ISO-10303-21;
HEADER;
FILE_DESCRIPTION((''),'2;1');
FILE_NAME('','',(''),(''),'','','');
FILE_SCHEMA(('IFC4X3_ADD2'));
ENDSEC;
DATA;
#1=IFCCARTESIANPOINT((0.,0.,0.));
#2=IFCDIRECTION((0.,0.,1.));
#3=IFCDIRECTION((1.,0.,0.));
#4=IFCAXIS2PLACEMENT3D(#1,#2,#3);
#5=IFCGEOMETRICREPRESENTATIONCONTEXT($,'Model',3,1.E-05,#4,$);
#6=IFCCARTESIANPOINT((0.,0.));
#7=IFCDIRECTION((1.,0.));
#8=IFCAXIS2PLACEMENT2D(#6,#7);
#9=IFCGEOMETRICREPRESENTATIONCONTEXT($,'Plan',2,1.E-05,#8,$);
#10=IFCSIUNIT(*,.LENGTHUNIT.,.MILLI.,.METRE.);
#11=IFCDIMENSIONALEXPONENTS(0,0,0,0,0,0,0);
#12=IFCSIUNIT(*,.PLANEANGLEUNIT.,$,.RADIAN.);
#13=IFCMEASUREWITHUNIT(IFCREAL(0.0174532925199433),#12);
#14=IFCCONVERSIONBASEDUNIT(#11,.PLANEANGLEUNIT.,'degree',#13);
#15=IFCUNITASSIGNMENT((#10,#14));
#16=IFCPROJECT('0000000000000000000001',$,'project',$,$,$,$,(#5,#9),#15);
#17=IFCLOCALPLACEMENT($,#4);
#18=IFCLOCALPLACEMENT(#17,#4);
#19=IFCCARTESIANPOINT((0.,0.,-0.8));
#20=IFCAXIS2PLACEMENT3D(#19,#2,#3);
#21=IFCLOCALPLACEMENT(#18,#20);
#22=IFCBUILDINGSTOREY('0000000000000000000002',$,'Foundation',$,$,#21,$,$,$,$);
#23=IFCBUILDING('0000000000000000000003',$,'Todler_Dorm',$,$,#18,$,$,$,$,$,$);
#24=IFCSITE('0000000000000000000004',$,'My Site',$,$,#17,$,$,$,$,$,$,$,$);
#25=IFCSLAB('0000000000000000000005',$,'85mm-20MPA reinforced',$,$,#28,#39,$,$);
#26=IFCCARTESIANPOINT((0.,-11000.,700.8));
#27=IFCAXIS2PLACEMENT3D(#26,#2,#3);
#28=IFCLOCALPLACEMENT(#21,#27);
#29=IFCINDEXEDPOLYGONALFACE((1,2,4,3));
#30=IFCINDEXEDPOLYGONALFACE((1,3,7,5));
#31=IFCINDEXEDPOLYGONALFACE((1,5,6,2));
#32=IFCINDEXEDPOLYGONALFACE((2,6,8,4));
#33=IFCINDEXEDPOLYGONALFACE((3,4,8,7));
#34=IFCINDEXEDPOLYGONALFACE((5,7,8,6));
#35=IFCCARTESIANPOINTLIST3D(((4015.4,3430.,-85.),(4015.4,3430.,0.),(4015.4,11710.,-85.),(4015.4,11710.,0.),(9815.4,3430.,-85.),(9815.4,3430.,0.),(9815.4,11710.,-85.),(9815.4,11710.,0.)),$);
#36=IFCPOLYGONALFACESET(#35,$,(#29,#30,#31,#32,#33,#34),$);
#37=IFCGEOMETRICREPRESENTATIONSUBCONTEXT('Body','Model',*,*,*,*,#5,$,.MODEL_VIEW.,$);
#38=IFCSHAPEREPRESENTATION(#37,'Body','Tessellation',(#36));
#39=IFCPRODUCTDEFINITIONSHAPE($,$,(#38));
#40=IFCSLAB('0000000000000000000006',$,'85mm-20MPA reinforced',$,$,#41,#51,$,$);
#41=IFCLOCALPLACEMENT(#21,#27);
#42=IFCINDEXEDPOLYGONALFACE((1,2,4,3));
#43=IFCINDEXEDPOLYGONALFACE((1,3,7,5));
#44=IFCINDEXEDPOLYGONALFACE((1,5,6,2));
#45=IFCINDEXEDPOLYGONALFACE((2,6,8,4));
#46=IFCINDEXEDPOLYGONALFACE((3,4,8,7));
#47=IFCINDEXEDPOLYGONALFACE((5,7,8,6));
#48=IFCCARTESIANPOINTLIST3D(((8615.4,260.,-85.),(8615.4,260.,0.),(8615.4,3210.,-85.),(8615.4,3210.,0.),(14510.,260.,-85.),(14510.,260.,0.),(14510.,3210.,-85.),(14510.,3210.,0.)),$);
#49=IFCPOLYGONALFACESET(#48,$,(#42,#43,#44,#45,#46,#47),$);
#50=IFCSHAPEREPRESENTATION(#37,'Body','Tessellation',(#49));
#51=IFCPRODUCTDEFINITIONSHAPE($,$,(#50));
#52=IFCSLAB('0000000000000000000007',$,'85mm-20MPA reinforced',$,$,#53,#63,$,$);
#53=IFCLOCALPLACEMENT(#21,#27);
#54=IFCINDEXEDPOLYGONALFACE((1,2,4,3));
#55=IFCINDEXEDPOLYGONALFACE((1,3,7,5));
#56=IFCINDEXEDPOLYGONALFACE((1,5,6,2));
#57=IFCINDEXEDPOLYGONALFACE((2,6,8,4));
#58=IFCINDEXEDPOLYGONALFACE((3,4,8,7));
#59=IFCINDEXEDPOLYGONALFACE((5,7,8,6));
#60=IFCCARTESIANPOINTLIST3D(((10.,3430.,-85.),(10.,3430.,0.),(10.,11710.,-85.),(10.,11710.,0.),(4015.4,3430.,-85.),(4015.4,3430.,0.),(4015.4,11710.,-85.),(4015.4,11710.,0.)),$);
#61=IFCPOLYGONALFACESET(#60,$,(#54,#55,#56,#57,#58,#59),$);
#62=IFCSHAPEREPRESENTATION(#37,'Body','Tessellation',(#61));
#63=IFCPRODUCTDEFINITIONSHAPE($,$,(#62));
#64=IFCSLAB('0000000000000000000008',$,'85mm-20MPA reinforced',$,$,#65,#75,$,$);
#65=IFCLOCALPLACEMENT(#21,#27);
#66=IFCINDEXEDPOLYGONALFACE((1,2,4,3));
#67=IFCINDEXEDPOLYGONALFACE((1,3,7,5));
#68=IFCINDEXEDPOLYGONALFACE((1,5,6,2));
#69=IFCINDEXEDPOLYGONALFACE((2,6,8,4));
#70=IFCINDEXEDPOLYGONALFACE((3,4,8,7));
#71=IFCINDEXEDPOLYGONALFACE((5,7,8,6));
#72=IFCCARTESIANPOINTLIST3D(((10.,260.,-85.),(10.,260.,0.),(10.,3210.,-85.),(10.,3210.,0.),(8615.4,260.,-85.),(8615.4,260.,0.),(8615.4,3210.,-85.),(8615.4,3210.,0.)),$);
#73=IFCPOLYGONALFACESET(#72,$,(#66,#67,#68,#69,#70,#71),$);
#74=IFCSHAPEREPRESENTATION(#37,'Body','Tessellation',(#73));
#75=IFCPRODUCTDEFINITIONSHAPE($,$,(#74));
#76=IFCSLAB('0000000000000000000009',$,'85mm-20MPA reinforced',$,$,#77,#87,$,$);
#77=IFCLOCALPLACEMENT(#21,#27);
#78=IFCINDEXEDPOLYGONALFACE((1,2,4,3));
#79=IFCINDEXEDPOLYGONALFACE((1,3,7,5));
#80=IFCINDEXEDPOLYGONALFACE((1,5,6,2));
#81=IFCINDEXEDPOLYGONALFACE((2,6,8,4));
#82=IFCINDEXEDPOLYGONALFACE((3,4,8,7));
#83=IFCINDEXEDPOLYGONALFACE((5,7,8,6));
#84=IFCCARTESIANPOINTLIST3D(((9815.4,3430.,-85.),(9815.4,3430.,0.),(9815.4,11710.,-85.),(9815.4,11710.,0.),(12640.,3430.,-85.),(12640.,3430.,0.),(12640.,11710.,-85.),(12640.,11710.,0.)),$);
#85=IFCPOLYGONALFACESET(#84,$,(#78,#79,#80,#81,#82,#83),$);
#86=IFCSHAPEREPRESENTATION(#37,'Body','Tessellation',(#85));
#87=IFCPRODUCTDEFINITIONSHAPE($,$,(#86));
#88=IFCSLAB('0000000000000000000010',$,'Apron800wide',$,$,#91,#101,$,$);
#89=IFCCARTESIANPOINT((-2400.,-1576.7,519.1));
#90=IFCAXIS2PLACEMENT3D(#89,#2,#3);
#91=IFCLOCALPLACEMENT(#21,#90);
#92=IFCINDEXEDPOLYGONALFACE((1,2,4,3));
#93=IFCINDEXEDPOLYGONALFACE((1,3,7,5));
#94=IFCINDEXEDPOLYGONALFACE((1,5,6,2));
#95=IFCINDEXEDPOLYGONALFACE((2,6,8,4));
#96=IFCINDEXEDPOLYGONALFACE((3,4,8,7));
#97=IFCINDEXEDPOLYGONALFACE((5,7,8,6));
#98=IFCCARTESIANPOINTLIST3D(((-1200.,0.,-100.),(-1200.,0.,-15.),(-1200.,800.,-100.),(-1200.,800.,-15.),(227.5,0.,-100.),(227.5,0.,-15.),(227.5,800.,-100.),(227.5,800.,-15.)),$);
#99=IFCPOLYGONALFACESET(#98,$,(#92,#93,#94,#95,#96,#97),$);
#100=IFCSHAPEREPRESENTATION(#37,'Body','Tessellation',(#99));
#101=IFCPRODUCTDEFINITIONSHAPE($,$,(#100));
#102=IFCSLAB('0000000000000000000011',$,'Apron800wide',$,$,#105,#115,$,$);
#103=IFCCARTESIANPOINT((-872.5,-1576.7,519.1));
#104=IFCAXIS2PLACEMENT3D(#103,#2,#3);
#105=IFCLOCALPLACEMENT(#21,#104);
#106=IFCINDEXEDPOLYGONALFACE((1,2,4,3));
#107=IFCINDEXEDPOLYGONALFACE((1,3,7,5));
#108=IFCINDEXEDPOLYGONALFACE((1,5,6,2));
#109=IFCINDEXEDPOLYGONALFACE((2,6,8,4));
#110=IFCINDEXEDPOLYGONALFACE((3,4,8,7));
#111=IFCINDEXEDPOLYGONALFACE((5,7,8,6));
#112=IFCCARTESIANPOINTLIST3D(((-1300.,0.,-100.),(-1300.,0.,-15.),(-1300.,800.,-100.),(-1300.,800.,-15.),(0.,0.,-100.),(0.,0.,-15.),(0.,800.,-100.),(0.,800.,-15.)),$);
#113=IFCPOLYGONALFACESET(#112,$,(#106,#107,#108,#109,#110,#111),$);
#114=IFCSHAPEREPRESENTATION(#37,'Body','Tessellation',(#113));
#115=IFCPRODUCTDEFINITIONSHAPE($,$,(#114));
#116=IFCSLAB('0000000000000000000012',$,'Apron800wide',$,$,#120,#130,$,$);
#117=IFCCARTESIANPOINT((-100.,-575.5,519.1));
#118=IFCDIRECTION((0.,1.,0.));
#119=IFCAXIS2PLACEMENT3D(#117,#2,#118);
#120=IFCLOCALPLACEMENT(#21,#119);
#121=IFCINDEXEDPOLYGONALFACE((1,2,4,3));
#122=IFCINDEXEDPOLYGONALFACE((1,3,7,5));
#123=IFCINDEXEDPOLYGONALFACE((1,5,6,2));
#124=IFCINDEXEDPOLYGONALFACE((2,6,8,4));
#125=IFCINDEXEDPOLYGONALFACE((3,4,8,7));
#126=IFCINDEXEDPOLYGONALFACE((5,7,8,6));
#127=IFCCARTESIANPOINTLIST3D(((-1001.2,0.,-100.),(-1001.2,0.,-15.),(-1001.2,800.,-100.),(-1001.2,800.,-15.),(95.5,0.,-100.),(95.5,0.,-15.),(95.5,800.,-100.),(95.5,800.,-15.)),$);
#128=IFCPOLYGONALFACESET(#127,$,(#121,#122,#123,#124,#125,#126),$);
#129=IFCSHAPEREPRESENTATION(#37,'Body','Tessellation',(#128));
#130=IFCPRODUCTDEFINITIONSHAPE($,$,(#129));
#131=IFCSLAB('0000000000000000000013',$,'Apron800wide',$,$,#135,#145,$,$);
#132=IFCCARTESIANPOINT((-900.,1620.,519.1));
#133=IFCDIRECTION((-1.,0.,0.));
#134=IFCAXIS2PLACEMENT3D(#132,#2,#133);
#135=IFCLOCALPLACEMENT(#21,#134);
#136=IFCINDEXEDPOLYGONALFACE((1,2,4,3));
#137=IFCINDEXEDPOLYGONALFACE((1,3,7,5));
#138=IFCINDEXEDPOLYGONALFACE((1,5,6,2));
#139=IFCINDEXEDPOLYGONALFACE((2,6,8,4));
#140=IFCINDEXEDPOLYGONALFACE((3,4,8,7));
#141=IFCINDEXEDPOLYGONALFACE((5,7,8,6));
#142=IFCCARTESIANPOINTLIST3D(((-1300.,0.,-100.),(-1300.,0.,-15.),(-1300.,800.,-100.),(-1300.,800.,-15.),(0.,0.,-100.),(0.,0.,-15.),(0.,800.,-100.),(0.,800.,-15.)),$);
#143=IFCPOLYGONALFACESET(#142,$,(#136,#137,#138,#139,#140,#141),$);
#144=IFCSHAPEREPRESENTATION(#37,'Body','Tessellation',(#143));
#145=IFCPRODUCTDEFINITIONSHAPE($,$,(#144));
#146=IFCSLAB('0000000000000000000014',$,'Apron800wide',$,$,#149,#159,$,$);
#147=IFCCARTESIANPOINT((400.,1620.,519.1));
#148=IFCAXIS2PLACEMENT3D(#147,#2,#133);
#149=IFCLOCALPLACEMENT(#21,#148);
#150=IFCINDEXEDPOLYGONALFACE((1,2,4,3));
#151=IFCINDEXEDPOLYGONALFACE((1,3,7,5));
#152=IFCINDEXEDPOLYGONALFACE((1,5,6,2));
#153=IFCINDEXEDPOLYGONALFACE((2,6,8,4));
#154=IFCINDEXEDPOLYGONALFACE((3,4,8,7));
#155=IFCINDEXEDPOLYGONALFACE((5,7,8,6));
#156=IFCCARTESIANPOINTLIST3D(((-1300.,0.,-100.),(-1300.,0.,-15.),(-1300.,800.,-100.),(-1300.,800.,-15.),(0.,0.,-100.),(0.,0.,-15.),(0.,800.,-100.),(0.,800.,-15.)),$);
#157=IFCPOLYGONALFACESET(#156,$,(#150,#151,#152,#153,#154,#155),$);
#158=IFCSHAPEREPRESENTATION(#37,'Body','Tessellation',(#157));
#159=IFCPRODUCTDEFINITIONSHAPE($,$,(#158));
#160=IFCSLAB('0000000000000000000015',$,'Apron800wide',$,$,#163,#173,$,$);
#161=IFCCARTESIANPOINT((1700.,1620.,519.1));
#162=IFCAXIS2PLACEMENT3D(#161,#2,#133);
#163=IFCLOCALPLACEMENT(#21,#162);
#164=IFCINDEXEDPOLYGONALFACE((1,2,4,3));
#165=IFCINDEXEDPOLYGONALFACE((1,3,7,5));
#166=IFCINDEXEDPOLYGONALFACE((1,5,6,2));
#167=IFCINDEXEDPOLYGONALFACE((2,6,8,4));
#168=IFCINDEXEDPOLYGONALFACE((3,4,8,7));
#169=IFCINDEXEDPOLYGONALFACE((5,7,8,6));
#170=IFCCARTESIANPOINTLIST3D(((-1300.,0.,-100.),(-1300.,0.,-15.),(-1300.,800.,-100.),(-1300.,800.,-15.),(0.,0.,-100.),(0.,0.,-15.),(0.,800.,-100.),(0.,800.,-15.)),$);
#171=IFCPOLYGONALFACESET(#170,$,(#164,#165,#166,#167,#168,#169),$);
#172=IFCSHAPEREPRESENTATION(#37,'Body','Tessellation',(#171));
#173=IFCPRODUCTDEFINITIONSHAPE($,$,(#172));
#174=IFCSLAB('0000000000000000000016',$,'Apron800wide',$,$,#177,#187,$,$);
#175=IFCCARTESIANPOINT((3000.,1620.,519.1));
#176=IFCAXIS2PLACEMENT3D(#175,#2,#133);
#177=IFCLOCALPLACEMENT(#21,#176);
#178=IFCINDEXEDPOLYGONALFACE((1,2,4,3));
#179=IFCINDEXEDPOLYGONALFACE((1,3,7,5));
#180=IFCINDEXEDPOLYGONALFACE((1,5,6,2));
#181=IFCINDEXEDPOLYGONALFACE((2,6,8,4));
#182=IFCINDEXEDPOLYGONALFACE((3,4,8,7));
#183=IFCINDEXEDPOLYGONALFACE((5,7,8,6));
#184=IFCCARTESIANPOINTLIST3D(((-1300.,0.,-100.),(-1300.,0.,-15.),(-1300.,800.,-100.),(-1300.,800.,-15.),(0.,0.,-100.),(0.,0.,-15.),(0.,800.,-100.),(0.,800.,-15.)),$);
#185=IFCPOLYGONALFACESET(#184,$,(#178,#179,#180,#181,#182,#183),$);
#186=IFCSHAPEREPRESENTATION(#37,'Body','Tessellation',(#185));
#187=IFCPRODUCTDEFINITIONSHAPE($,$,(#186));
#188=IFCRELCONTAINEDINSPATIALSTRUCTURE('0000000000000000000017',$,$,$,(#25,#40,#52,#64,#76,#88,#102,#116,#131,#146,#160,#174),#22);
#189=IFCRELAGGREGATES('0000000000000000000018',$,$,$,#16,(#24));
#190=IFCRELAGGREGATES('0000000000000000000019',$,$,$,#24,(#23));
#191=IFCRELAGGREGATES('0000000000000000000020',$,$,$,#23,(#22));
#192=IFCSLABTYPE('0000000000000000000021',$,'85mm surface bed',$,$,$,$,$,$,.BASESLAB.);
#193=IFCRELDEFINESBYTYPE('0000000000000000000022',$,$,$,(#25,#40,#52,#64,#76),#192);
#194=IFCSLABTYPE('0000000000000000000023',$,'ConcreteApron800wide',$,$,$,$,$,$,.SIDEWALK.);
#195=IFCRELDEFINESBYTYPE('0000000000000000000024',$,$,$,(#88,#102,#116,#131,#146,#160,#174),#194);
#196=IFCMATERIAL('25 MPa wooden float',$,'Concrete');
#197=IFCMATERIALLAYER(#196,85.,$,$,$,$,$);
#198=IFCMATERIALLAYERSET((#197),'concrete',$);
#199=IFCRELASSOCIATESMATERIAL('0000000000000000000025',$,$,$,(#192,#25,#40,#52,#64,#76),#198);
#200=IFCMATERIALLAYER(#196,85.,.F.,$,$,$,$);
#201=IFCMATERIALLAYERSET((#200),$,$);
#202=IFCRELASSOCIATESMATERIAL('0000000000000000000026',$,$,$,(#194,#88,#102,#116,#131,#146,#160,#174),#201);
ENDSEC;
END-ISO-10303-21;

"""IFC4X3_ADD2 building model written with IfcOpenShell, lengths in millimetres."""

from ifc_helpers import new_model, entity, si_unit, converted_unit, frame, origin_with_axes, origin_2d_with_axis, place, context, subcontext, project, spatial, indexed_curve, outline, extrude, material, layer, layer_set, layer_usage, type_object, element, save


model = new_model("IFC4X3_ADD2")

# Units and contexts
model_context = context("Model", 3, precision=1e-05, world=origin_with_axes())
plan_context = context("Plan", 2, precision=1e-05, world=origin_2d_with_axis())
body_context = subcontext(model_context, "Body", "Model", "MODEL_VIEW")
ifc_project = project(units=[si_unit("LENGTHUNIT", "METRE", prefix="MILLI"), converted_unit("PLANEANGLEUNIT", "degree", entity("IfcReal", 0.0174532925199433), si_unit("PLANEANGLEUNIT", "RADIAN"), dimensions=[0, 0, 0, 0, 0, 0, 0])], contexts=[model_context, plan_context])

# Site, building, storey
site_placement = place(None, origin_with_axes())
site = spatial("IfcSite", under=ifc_project, at=site_placement, Name="My Site")
building_placement = place(site_placement, origin_with_axes())
building = spatial("IfcBuilding", under=site, at=building_placement, Name="Todler_Dorm")
storey_placement = place(building_placement, frame((0.0, 0.0, -0.8), z_axis=(0.0, 0.0, 1.0), x_axis=(1.0, 0.0, 0.0)))
storey = spatial("IfcBuildingStorey", under=building, at=storey_placement, Name="Foundation")

# Slabs
ifc_material_1 = material(Name="25 MPa wooden float", Category="Concrete")
ifc_layer_1 = layer(ifc_material_1, 85.0)
ifc_layer_set_1 = layer_set([ifc_layer_1], Name="concrete")
ifc_layer_usage_1 = layer_usage(ifc_layer_set_1, "AXIS3", "POSITIVE", -85.0)
slab_type_1 = type_object("IfcSlabType", Name="85mm surface bed", PredefinedType="BASESLAB", material=ifc_layer_set_1)
slab_1_placement = place(storey_placement, frame((0.0, -11000.0, 700.8), z_axis=(0.0, 0.0, 1.0), x_axis=(1.0, 0.0, 0.0)))
element("IfcSlab", 1, at=slab_1_placement, inside=storey, type_object=slab_type_1, material=ifc_layer_usage_1, Name="85mm-20MPA reinforced", context=body_context, shape_type="SweptSolid", body=[
    extrude(outline(indexed_curve([(4015.4, 11710.0), (9815.4, 11710.0), (9815.4, 3430.0), (4015.4, 3430.0), (4015.4, 11710.0)])), frame((0.0, 0.0, -85.0), z_axis=(0.0, 0.0, 1.0), x_axis=(1.0, 0.0, 0.0)), (0.0, 0.0, 1.0), 85.0),
])
ifc_layer_usage_2 = layer_usage(ifc_layer_set_1, "AXIS3", "POSITIVE", -85.0)
slab_2_placement = place(storey_placement, frame((0.0, -11000.0, 700.8), z_axis=(0.0, 0.0, 1.0), x_axis=(1.0, 0.0, 0.0)))
element("IfcSlab", 2, at=slab_2_placement, inside=storey, type_object=slab_type_1, material=ifc_layer_usage_2, Name="85mm-20MPA reinforced", context=body_context, shape_type="SweptSolid", body=[
    extrude(outline(indexed_curve([(8615.4, 3210.0), (14510.0, 3210.0), (14510.0, 260.0), (8615.4, 260.0), (8615.4, 3210.0)])), frame((0.0, 0.0, -85.0), z_axis=(0.0, 0.0, 1.0), x_axis=(1.0, 0.0, 0.0)), (0.0, 0.0, 1.0), 85.0),
])
ifc_layer_usage_3 = layer_usage(ifc_layer_set_1, "AXIS3", "POSITIVE", -85.0)
slab_3_placement = place(storey_placement, frame((0.0, -11000.0, 700.8), z_axis=(0.0, 0.0, 1.0), x_axis=(1.0, 0.0, 0.0)))
element("IfcSlab", 3, at=slab_3_placement, inside=storey, type_object=slab_type_1, material=ifc_layer_usage_3, Name="85mm-20MPA reinforced", context=body_context, shape_type="SweptSolid", body=[
    extrude(outline(indexed_curve([(10.0, 11710.0), (4015.4, 11710.0), (4015.4, 3430.0), (10.0, 3430.0), (10.0, 11710.0)])), frame((0.0, 0.0, -85.0), z_axis=(0.0, 0.0, 1.0), x_axis=(1.0, 0.0, 0.0)), (0.0, 0.0, 1.0), 85.0),
])
ifc_layer_usage_4 = layer_usage(ifc_layer_set_1, "AXIS3", "POSITIVE", -85.0)
slab_4_placement = place(storey_placement, frame((0.0, -11000.0, 700.8), z_axis=(0.0, 0.0, 1.0), x_axis=(1.0, 0.0, 0.0)))
element("IfcSlab", 4, at=slab_4_placement, inside=storey, type_object=slab_type_1, material=ifc_layer_usage_4, Name="85mm-20MPA reinforced", context=body_context, shape_type="SweptSolid", body=[
    extrude(outline(indexed_curve([(10.0, 3210.0), (8615.4, 3210.0), (8615.4, 260.0), (10.0, 260.0), (10.0, 3210.0)])), frame((0.0, 0.0, -85.0), z_axis=(0.0, 0.0, 1.0), x_axis=(1.0, 0.0, 0.0)), (0.0, 0.0, 1.0), 85.0),
])
ifc_layer_usage_5 = layer_usage(ifc_layer_set_1, "AXIS3", "POSITIVE", -85.0)
slab_5_placement = place(storey_placement, frame((0.0, -11000.0, 700.8), z_axis=(0.0, 0.0, 1.0), x_axis=(1.0, 0.0, 0.0)))
element("IfcSlab", 5, at=slab_5_placement, inside=storey, type_object=slab_type_1, material=ifc_layer_usage_5, Name="85mm-20MPA reinforced", context=body_context, shape_type="SweptSolid", body=[
    extrude(outline(indexed_curve([(9815.4, 11710.0), (12640.0, 11710.0), (12640.0, 3430.0), (9815.4, 3430.0), (9815.4, 11710.0)])), frame((0.0, 0.0, -85.0), z_axis=(0.0, 0.0, 1.0), x_axis=(1.0, 0.0, 0.0)), (0.0, 0.0, 1.0), 85.0),
])
ifc_layer_2 = layer(ifc_material_1, 85.0, ventilated=False)
ifc_layer_set_2 = layer_set([ifc_layer_2])
ifc_layer_usage_6 = layer_usage(ifc_layer_set_2, "AXIS3", "POSITIVE", -100.0)
slab_type_2 = type_object("IfcSlabType", Name="ConcreteApron800wide", PredefinedType="SIDEWALK", material=ifc_layer_set_2)
slab_6_placement = place(storey_placement, frame((-2400.0, -1576.7, 519.1), z_axis=(0.0, 0.0, 1.0), x_axis=(1.0, 0.0, 0.0)))
element("IfcSlab", 6, at=slab_6_placement, inside=storey, type_object=slab_type_2, material=ifc_layer_usage_6, Name="Apron800wide", context=body_context, shape_type="SweptSolid", body=[
    extrude(outline(indexed_curve([(-1200.0, 0.0), (-1200.0, 800.0), (227.5, 800.0), (227.5, 0.0), (-1200.0, 0.0)])), frame((0.0, 0.0, -100.0), z_axis=(0.0, 0.0, 1.0), x_axis=(1.0, 0.0, 0.0)), (0.0, 0.0, 1.0), 85.0),
])
ifc_layer_usage_7 = layer_usage(ifc_layer_set_2, "AXIS3", "POSITIVE", -100.0)
slab_7_placement = place(storey_placement, frame((-872.5, -1576.7, 519.1), z_axis=(0.0, 0.0, 1.0), x_axis=(1.0, 0.0, 0.0)))
element("IfcSlab", 7, at=slab_7_placement, inside=storey, type_object=slab_type_2, material=ifc_layer_usage_7, Name="Apron800wide", context=body_context, shape_type="SweptSolid", body=[
    extrude(outline(indexed_curve([(-1300.0, 0.0), (-1300.0, 800.0), (0.0, 800.0), (0.0, 0.0), (-1300.0, 0.0)])), frame((0.0, 0.0, -100.0), z_axis=(0.0, 0.0, 1.0), x_axis=(1.0, 0.0, 0.0)), (0.0, 0.0, 1.0), 85.0),
])
ifc_layer_usage_8 = layer_usage(ifc_layer_set_2, "AXIS3", "POSITIVE", -100.0)
slab_8_placement = place(storey_placement, frame((-100.0, -575.5, 519.1), z_axis=(0.0, 0.0, 1.0), x_axis=(0.0, 1.0, 0.0)))
element("IfcSlab", 8, at=slab_8_placement, inside=storey, type_object=slab_type_2, material=ifc_layer_usage_8, Name="Apron800wide", context=body_context, shape_type="SweptSolid", body=[
    extrude(outline(indexed_curve([(95.5, 0.0), (95.5, 800.0), (-1001.2, 800.0), (-1001.2, 0.0), (95.5, 0.0)])), frame((0.0, 0.0, -100.0), z_axis=(0.0, 0.0, 1.0), x_axis=(1.0, 0.0, 0.0)), (0.0, 0.0, 1.0), 85.0),
])
ifc_layer_usage_9 = layer_usage(ifc_layer_set_2, "AXIS3", "POSITIVE", -100.0)
slab_9_placement = place(storey_placement, frame((-900.0, 1620.0, 519.1), z_axis=(0.0, 0.0, 1.0), x_axis=(-1.0, 0.0, 0.0)))
element("IfcSlab", 9, at=slab_9_placement, inside=storey, type_object=slab_type_2, material=ifc_layer_usage_9, Name="Apron800wide", context=body_context, shape_type="SweptSolid", body=[
    extrude(outline(indexed_curve([(0.0, 0.0), (0.0, 800.0), (-1300.0, 800.0), (-1300.0, 0.0), (0.0, 0.0)])), frame((0.0, 0.0, -100.0), z_axis=(0.0, 0.0, 1.0), x_axis=(1.0, 0.0, 0.0)), (0.0, 0.0, 1.0), 85.0),
])
ifc_layer_usage_10 = layer_usage(ifc_layer_set_2, "AXIS3", "POSITIVE", -100.0)
slab_10_placement = place(storey_placement, frame((400.0, 1620.0, 519.1), z_axis=(0.0, 0.0, 1.0), x_axis=(-1.0, 0.0, 0.0)))
element("IfcSlab", 10, at=slab_10_placement, inside=storey, type_object=slab_type_2, material=ifc_layer_usage_10, Name="Apron800wide", context=body_context, shape_type="SweptSolid", body=[
    extrude(outline(indexed_curve([(0.0, 0.0), (0.0, 800.0), (-1300.0, 800.0), (-1300.0, 0.0), (0.0, 0.0)])), frame((0.0, 0.0, -100.0), z_axis=(0.0, 0.0, 1.0), x_axis=(1.0, 0.0, 0.0)), (0.0, 0.0, 1.0), 85.0),
])
ifc_layer_usage_11 = layer_usage(ifc_layer_set_2, "AXIS3", "POSITIVE", -100.0)
slab_11_placement = place(storey_placement, frame((1700.0, 1620.0, 519.1), z_axis=(0.0, 0.0, 1.0), x_axis=(-1.0, 0.0, 0.0)))
element("IfcSlab", 11, at=slab_11_placement, inside=storey, type_object=slab_type_2, material=ifc_layer_usage_11, Name="Apron800wide", context=body_context, shape_type="SweptSolid", body=[
    extrude(outline(indexed_curve([(0.0, 0.0), (0.0, 800.0), (-1300.0, 800.0), (-1300.0, 0.0), (0.0, 0.0)])), frame((0.0, 0.0, -100.0), z_axis=(0.0, 0.0, 1.0), x_axis=(1.0, 0.0, 0.0)), (0.0, 0.0, 1.0), 85.0),
])
ifc_layer_usage_12 = layer_usage(ifc_layer_set_2, "AXIS3", "POSITIVE", -100.0)
slab_12_placement = place(storey_placement, frame((3000.0, 1620.0, 519.1), z_axis=(0.0, 0.0, 1.0), x_axis=(-1.0, 0.0, 0.0)))
element("IfcSlab", 12, at=slab_12_placement, inside=storey, type_object=slab_type_2, material=ifc_layer_usage_12, Name="Apron800wide", context=body_context, shape_type="SweptSolid", body=[
    extrude(outline(indexed_curve([(0.0, 0.0), (0.0, 800.0), (-1300.0, 800.0), (-1300.0, 0.0), (0.0, 0.0)])), frame((0.0, 0.0, -100.0), z_axis=(0.0, 0.0, 1.0), x_axis=(1.0, 0.0, 0.0)), (0.0, 0.0, 1.0), 85.0),
])

save(model, "model.ifc")
